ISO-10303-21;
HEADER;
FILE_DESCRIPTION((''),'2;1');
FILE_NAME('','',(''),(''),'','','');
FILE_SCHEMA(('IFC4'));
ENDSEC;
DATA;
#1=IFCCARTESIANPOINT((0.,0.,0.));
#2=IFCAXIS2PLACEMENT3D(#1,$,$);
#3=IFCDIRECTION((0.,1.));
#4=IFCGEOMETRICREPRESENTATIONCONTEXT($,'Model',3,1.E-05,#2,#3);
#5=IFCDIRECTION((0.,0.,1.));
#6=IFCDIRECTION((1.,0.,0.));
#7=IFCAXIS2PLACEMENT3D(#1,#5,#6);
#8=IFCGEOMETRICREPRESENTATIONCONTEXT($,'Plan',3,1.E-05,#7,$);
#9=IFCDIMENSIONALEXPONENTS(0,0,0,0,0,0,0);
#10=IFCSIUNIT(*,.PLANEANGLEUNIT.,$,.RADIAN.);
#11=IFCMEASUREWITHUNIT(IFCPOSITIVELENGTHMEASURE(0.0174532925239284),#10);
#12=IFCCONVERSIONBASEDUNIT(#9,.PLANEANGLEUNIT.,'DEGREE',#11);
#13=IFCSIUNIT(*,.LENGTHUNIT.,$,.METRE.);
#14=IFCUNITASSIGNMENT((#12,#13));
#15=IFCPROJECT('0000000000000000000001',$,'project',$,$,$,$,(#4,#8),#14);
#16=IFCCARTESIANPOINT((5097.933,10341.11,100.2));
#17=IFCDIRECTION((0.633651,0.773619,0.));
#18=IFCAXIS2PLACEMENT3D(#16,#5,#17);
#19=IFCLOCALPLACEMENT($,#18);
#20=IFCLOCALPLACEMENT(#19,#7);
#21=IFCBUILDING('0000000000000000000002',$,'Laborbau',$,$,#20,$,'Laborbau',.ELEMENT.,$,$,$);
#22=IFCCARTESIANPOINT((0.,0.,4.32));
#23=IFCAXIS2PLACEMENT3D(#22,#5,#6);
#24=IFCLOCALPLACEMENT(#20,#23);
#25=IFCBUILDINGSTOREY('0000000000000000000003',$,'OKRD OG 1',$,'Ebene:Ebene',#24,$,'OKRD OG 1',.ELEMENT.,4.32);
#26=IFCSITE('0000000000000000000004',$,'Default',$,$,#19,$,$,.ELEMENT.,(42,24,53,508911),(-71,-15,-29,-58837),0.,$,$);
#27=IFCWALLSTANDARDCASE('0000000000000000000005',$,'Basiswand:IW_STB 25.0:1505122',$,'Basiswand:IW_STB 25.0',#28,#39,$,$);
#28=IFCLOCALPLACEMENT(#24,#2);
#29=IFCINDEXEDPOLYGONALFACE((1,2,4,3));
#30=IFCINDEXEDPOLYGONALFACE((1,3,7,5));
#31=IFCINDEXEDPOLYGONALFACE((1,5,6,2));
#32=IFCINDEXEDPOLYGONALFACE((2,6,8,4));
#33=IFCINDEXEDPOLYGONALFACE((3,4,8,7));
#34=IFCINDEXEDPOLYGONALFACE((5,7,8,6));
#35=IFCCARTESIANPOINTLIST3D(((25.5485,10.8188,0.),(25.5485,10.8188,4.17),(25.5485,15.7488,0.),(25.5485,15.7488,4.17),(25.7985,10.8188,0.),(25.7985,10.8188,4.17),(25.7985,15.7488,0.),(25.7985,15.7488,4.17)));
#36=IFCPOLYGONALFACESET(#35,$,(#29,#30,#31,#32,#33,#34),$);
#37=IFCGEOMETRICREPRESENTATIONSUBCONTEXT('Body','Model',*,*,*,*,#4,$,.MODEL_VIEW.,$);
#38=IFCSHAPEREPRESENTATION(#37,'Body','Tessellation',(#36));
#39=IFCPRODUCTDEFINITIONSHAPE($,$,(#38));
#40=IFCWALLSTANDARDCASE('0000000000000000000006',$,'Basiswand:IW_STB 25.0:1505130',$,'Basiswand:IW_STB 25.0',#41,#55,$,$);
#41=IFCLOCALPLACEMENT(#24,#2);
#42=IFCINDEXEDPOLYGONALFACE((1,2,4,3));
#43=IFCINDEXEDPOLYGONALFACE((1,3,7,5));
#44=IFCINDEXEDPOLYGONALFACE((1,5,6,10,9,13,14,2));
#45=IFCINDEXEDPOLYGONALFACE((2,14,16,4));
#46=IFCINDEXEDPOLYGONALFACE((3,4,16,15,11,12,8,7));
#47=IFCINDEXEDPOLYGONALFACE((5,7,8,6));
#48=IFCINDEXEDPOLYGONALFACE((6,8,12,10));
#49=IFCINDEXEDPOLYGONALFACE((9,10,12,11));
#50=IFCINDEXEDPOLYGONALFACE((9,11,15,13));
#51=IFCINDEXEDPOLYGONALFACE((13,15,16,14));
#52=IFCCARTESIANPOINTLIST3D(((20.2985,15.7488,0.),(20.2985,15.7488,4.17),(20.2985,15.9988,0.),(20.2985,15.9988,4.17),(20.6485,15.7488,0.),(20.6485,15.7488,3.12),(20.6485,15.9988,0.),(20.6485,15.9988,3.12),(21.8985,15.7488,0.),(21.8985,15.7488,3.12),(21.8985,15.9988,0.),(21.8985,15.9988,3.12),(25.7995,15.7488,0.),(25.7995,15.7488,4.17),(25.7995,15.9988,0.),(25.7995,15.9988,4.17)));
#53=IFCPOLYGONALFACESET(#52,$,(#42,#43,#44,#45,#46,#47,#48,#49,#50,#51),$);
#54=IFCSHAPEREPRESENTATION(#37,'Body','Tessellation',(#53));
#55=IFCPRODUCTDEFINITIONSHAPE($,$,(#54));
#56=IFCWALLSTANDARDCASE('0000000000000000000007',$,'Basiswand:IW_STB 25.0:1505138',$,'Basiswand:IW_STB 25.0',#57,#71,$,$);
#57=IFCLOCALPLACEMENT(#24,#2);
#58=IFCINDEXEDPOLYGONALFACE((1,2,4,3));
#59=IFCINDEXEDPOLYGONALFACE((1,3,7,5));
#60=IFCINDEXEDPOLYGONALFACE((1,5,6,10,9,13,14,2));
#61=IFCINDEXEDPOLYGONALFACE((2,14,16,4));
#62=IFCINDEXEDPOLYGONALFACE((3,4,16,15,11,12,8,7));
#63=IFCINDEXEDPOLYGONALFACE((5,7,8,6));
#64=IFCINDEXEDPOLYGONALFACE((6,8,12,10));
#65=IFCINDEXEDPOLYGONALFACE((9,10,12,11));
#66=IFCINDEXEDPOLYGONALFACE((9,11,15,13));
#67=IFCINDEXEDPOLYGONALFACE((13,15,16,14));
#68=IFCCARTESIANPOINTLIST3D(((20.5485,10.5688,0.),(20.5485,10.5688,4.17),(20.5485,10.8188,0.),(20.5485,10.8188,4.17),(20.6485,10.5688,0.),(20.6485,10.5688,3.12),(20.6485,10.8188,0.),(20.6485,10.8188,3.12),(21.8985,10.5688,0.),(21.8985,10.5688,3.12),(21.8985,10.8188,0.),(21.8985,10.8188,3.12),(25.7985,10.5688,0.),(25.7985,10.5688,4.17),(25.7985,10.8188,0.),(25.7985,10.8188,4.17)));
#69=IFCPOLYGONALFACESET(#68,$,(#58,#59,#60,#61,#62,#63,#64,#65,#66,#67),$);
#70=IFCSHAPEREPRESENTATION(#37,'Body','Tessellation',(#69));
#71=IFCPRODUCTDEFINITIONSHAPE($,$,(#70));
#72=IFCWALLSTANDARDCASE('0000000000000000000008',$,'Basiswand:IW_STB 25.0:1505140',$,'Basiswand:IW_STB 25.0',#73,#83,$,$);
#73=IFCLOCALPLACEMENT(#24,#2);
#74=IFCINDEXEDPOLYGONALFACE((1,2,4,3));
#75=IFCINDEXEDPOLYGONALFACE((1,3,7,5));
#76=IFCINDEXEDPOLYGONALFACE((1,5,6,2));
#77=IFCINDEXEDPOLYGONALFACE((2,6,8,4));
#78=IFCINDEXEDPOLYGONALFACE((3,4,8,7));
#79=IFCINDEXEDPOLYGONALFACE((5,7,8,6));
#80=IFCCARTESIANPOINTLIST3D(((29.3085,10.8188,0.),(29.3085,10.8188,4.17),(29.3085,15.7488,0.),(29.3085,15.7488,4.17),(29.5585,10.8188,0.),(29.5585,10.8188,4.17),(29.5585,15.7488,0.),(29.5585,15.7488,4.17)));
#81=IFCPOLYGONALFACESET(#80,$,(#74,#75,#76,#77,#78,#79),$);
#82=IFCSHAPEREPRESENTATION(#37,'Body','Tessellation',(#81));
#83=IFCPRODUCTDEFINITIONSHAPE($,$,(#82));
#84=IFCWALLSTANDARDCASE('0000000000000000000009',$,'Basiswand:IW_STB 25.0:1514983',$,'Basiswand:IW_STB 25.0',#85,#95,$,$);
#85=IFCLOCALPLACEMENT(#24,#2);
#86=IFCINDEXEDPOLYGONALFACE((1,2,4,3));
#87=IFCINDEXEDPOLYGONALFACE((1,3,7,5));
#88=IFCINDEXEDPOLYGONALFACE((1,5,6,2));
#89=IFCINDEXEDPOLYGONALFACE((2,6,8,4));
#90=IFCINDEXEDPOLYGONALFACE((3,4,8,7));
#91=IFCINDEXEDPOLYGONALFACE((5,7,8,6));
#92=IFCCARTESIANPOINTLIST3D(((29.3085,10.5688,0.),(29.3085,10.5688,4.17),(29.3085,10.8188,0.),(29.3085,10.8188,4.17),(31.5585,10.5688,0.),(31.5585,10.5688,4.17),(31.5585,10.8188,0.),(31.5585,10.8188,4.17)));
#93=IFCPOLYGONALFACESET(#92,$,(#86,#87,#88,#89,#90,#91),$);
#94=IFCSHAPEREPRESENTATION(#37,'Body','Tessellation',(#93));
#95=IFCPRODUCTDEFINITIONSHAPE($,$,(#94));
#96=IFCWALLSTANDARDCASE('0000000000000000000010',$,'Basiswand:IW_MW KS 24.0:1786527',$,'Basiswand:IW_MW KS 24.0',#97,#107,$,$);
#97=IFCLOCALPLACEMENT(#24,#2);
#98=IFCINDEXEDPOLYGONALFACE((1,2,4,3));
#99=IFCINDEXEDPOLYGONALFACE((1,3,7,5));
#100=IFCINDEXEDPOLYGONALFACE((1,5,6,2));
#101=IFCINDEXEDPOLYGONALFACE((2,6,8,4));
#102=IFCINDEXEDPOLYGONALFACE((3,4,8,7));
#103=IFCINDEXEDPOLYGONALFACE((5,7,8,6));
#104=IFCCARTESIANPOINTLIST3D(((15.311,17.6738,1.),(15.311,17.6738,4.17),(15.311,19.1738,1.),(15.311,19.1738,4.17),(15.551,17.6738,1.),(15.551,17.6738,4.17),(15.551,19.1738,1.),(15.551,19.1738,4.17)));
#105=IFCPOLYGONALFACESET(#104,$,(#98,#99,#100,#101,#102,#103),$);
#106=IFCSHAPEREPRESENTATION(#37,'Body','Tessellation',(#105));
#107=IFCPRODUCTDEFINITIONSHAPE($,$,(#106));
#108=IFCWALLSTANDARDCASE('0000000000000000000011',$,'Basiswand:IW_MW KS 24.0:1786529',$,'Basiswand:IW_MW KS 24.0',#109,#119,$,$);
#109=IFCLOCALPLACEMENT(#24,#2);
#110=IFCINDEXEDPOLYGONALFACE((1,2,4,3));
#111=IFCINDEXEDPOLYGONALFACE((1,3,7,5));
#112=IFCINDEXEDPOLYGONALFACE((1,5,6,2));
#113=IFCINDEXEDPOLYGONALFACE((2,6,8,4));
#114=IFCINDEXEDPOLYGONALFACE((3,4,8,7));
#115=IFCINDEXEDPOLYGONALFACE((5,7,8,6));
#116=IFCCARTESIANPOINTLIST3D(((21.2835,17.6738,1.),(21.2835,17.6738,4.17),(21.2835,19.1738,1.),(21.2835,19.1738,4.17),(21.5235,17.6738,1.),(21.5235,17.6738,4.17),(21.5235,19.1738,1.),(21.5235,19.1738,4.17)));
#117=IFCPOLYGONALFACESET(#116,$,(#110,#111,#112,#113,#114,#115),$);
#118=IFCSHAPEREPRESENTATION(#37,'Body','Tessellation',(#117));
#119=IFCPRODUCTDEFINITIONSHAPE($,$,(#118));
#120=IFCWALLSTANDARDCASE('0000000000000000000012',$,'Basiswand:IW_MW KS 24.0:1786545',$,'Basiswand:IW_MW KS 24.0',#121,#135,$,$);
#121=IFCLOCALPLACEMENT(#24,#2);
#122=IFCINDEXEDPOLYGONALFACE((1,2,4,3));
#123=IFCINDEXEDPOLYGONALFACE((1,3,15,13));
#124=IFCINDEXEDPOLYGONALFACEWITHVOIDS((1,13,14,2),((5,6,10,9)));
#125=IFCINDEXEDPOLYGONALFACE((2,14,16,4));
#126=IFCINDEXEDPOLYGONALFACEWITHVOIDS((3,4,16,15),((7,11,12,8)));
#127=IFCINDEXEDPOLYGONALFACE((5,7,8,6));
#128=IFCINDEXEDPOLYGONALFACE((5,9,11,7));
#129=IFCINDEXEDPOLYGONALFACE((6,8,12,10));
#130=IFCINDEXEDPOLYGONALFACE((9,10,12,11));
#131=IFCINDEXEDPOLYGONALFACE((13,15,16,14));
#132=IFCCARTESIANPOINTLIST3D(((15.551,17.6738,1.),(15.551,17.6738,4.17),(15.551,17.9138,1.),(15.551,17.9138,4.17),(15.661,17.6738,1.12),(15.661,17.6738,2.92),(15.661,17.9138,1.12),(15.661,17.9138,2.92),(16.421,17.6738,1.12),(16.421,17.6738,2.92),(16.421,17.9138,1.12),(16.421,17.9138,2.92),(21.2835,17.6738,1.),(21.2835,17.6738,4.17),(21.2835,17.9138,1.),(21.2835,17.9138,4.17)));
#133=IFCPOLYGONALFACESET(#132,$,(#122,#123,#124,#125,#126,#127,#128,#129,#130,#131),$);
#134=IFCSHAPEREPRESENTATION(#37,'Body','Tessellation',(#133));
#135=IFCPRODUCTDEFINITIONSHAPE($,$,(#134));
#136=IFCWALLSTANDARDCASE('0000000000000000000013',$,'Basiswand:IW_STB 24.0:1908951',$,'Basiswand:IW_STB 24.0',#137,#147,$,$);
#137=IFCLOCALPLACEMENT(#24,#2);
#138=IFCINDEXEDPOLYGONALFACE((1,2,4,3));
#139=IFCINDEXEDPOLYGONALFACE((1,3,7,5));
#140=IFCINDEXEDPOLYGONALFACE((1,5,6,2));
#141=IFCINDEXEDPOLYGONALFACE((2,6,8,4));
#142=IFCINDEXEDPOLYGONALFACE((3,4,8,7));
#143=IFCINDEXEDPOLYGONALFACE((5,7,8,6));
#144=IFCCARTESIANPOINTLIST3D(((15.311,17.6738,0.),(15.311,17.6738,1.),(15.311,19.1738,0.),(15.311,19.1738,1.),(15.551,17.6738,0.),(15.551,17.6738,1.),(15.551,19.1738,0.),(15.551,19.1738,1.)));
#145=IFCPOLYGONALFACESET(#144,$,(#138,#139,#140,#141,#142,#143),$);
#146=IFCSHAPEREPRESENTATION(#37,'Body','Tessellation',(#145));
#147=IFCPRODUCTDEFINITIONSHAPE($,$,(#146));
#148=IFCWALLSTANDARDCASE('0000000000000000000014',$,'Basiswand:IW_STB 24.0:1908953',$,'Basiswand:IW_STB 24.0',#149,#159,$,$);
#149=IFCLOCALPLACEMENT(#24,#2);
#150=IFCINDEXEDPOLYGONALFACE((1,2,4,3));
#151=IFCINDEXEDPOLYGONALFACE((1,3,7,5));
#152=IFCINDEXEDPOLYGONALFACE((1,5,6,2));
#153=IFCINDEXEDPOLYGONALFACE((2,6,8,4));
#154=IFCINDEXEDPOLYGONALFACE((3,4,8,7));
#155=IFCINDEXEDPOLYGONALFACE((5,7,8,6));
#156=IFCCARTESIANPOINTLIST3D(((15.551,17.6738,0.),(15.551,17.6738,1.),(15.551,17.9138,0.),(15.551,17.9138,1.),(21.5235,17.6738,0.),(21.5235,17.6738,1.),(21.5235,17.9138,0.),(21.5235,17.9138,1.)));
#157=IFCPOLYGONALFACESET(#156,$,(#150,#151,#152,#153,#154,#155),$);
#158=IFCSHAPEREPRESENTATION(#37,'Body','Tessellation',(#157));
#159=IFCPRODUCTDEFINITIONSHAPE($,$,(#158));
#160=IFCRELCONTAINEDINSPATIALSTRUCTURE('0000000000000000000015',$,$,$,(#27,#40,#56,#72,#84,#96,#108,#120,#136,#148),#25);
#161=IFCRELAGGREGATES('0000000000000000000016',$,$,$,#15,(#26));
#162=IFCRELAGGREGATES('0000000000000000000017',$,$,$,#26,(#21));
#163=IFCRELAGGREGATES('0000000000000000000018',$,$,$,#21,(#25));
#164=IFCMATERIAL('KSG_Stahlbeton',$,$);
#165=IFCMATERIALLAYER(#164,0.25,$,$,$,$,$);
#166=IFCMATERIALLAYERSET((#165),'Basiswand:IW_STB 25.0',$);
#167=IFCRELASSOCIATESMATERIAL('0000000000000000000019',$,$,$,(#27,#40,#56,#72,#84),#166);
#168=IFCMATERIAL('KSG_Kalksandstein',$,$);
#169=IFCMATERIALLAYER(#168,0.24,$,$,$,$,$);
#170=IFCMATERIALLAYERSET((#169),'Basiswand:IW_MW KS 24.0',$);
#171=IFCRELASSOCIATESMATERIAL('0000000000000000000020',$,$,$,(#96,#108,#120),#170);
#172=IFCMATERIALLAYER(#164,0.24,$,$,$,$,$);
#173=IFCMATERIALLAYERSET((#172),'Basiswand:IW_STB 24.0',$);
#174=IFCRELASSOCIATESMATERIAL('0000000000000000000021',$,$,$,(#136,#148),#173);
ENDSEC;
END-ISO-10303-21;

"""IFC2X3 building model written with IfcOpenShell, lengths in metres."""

from ifc_helpers import new_model, entity, si_unit, converted_unit, direction, frame, frame_2d, origin, origin_with_axes, place, context, subcontext, project, spatial, rectangle, extrude, material, layer, layer_set, layer_usage, element, save


model = new_model("IFC2X3")

# Units and contexts
model_context = context("Model", 3, precision=1e-05, world=origin(), true_north=direction((0.0, 1.0)))
plan_context = context("Plan", 3, precision=1e-05, world=origin_with_axes())
body_context = subcontext(model_context, "Body", "Model", "MODEL_VIEW")
ifc_project = project(units=[converted_unit("PLANEANGLEUNIT", "DEGREE", entity("IfcPositiveLengthMeasure", 0.0174532925239284), si_unit("PLANEANGLEUNIT", "RADIAN"), dimensions=[0, 0, 0, 0, 0, 0, 0]), si_unit("LENGTHUNIT", "METRE")], contexts=[model_context, plan_context])

# Site, building, storey
site_placement = place(None, frame((5097.933, 10341.11, 100.2), z_axis=(0.0, 0.0, 1.0), x_axis=(0.633651, 0.773619, 0.0)))
site = spatial("IfcSite", under=ifc_project, at=site_placement, Name="Default", CompositionType="ELEMENT", RefLatitude=(42, 24, 53, 508911), RefLongitude=(-71, -15, -29, -58837), RefElevation=0.0)
building_placement = place(site_placement, origin_with_axes())
building = spatial("IfcBuilding", under=site, at=building_placement, Name="Laborbau", LongName="Laborbau", CompositionType="ELEMENT")
storey_placement = place(building_placement, frame((0.0, 0.0, 4.32), z_axis=(0.0, 0.0, 1.0), x_axis=(1.0, 0.0, 0.0)))
storey = spatial("IfcBuildingStorey", under=building, at=storey_placement, Name="OKRD OG 1", ObjectType="Ebene:Ebene", LongName="OKRD OG 1", CompositionType="ELEMENT", Elevation=4.32)

# Wall
ifc_material_1 = material(Name="KSG_Stahlbeton")
ifc_layer_1 = layer(ifc_material_1, 0.25)
ifc_layer_set_1 = layer_set([ifc_layer_1], Name="Basiswand:IW_STB 25.0")
ifc_layer_usage_1 = layer_usage(ifc_layer_set_1, "AXIS2", "NEGATIVE", 0.125)
wall_1_placement = place(storey_placement, frame((25.6735, 10.8188, 0.0), z_axis=(0.0, 0.0, 1.0), x_axis=(0.0, 1.0, 0.0)))
element("IfcWallStandardCase", 1, at=wall_1_placement, inside=storey, material=ifc_layer_usage_1, Name="Basiswand:IW_STB 25.0:1505122", ObjectType="Basiswand:IW_STB 25.0", context=body_context, shape_type="SweptSolid", body=[
    extrude(rectangle(XDim=4.93, YDim=0.25, at=frame_2d((2.465, 0.0), x_axis=(-1.0, 0.0))), origin(), (0.0, 0.0, 1.0), 4.17),
])

# Walls, openings
ifc_layer_usage_2 = layer_usage(ifc_layer_set_1, "AXIS2", "NEGATIVE", 0.125)
wall_2_placement = place(storey_placement, frame((20.2985, 15.8738, 0.0), z_axis=(0.0, 0.0, 1.0), x_axis=(1.0, 0.0, 0.0)))
wall_2 = element("IfcWallStandardCase", 2, at=wall_2_placement, inside=storey, material=ifc_layer_usage_2, Name="Basiswand:IW_STB 25.0:1505130", ObjectType="Basiswand:IW_STB 25.0", context=body_context, shape_type="SweptSolid", body=[
    extrude(rectangle(XDim=5.501, YDim=0.25, at=frame_2d((2.7505, 0.0), x_axis=(-1.0, 0.0))), origin(), (0.0, 0.0, 1.0), 4.17),
])
opening_1_placement = place(wall_2_placement, frame((-20.2985, -15.8738, 0.0), z_axis=(0.0, 0.0, 1.0), x_axis=(1.0, 0.0, 0.0)))
element("IfcOpeningElement", 3, at=opening_1_placement, cuts=wall_2, ObjectType="Opening", context=body_context, shape_type="SweptSolid", body=[
    extrude(rectangle(XDim=3.12, YDim=1.25, at=frame_2d((0.0, 0.0), x_axis=(1.0, 0.0))), frame((21.2735, 14.2248, 1.56), z_axis=(0.0, 1.0, 0.0), x_axis=(0.0, 0.0, 1.0)), (0.0, 0.0, 1.0), 3.048),
])
opening_2_placement = place(wall_2_placement, frame((1.6, 0.125, 0.0), z_axis=(0.0, 0.0, 1.0), x_axis=(1.0, 0.0, 0.0)))
element("IfcOpeningElement", 4, at=opening_2_placement, cuts=wall_2, ObjectType="Opening", context=body_context, shape_type="SweptSolid", body=[
    extrude(rectangle(XDim=3.12, YDim=1.25, at=frame_2d((1.56, 0.625), x_axis=(1.0, 0.0))), frame((0.0, 0.0, 0.0), z_axis=(0.0, -1.0, 0.0), x_axis=(0.0, 0.0, 1.0)), (0.0, 0.0, 1.0), 0.25),
])
ifc_layer_usage_3 = layer_usage(ifc_layer_set_1, "AXIS2", "NEGATIVE", 0.125)
wall_3_placement = place(storey_placement, frame((20.5485, 10.6938, 0.0), z_axis=(0.0, 0.0, 1.0), x_axis=(1.0, 0.0, 0.0)))
wall_3 = element("IfcWallStandardCase", 5, at=wall_3_placement, inside=storey, material=ifc_layer_usage_3, Name="Basiswand:IW_STB 25.0:1505138", ObjectType="Basiswand:IW_STB 25.0", context=body_context, shape_type="SweptSolid", body=[
    extrude(rectangle(XDim=5.25, YDim=0.25, at=frame_2d((2.625, 0.0), x_axis=(-1.0, 0.0))), origin(), (0.0, 0.0, 1.0), 4.17),
])
opening_3_placement = place(wall_3_placement, frame((-20.5485, -10.6938, 0.0), z_axis=(0.0, 0.0, 1.0), x_axis=(1.0, 0.0, 0.0)))
element("IfcOpeningElement", 6, at=opening_3_placement, cuts=wall_3, ObjectType="Opening", context=body_context, shape_type="SweptSolid", body=[
    extrude(rectangle(XDim=3.12, YDim=1.25, at=frame_2d((0.0, 0.0), x_axis=(1.0, 0.0))), frame((21.2735, 9.2948, 1.56), z_axis=(0.0, 1.0, 0.0), x_axis=(0.0, 0.0, 1.0)), (0.0, 0.0, 1.0), 3.048),
])
opening_4_placement = place(wall_3_placement, frame((0.1, -0.125, 0.0), z_axis=(0.0, 0.0, 1.0), x_axis=(1.0, 0.0, 0.0)))
element("IfcOpeningElement", 7, at=opening_4_placement, cuts=wall_3, ObjectType="Opening", context=body_context, shape_type="SweptSolid", body=[
    extrude(rectangle(XDim=3.12, YDim=1.25, at=frame_2d((1.56, 0.625), x_axis=(1.0, 0.0))), frame((0.0, 0.0, 0.0), z_axis=(0.0, 1.0, 0.0), x_axis=(0.0, 0.0, 1.0)), (0.0, 0.0, 1.0), 0.25),
])

# Walls
ifc_layer_usage_4 = layer_usage(ifc_layer_set_1, "AXIS2", "NEGATIVE", 0.125)
wall_4_placement = place(storey_placement, frame((29.4335, 10.8188, 0.0), z_axis=(0.0, 0.0, 1.0), x_axis=(0.0, 1.0, 0.0)))
element("IfcWallStandardCase", 8, at=wall_4_placement, inside=storey, material=ifc_layer_usage_4, Name="Basiswand:IW_STB 25.0:1505140", ObjectType="Basiswand:IW_STB 25.0", context=body_context, shape_type="SweptSolid", body=[
    extrude(rectangle(XDim=4.93, YDim=0.25, at=frame_2d((2.465, 0.0), x_axis=(-1.0, 0.0))), origin(), (0.0, 0.0, 1.0), 4.17),
])
ifc_layer_usage_5 = layer_usage(ifc_layer_set_1, "AXIS2", "NEGATIVE", 0.125)
wall_5_placement = place(storey_placement, frame((29.3085, 10.6938, 0.0), z_axis=(0.0, 0.0, 1.0), x_axis=(1.0, 0.0, 0.0)))
element("IfcWallStandardCase", 9, at=wall_5_placement, inside=storey, material=ifc_layer_usage_5, Name="Basiswand:IW_STB 25.0:1514983", ObjectType="Basiswand:IW_STB 25.0", context=body_context, shape_type="SweptSolid", body=[
    extrude(rectangle(XDim=2.25, YDim=0.25, at=frame_2d((1.125, 0.0), x_axis=(-1.0, 0.0))), origin(), (0.0, 0.0, 1.0), 4.17),
])
ifc_material_2 = material(Name="KSG_Kalksandstein")
ifc_layer_2 = layer(ifc_material_2, 0.24)
ifc_layer_set_2 = layer_set([ifc_layer_2], Name="Basiswand:IW_MW KS 24.0")
ifc_layer_usage_6 = layer_usage(ifc_layer_set_2, "AXIS2", "POSITIVE", -0.12)
wall_6_placement = place(storey_placement, frame((15.431, 19.1738, 1.0), z_axis=(0.0, 0.0, 1.0), x_axis=(0.0, -1.0, 0.0)))
element("IfcWallStandardCase", 10, at=wall_6_placement, inside=storey, material=ifc_layer_usage_6, Name="Basiswand:IW_MW KS 24.0:1786527", ObjectType="Basiswand:IW_MW KS 24.0", context=body_context, shape_type="SweptSolid", body=[
    extrude(rectangle(XDim=1.5, YDim=0.24, at=frame_2d((0.75, 0.0), x_axis=(-1.0, 0.0))), origin(), (0.0, 0.0, 1.0), 3.17),
])
ifc_layer_usage_7 = layer_usage(ifc_layer_set_2, "AXIS2", "POSITIVE", -0.12)
wall_7_placement = place(storey_placement, frame((21.4035, 17.6738, 1.0), z_axis=(0.0, 0.0, 1.0), x_axis=(0.0, 1.0, 0.0)))
element("IfcWallStandardCase", 11, at=wall_7_placement, inside=storey, material=ifc_layer_usage_7, Name="Basiswand:IW_MW KS 24.0:1786529", ObjectType="Basiswand:IW_MW KS 24.0", context=body_context, shape_type="SweptSolid", body=[
    extrude(rectangle(XDim=1.5, YDim=0.24, at=frame_2d((0.75, 0.0), x_axis=(-1.0, 0.0))), origin(), (0.0, 0.0, 1.0), 3.17),
])

# Wall, openings
ifc_layer_usage_8 = layer_usage(ifc_layer_set_2, "AXIS2", "POSITIVE", -0.12)
wall_8_placement = place(storey_placement, frame((15.551, 17.7938, 1.0), z_axis=(0.0, 0.0, 1.0), x_axis=(1.0, 0.0, 0.0)))
wall_8 = element("IfcWallStandardCase", 12, at=wall_8_placement, inside=storey, material=ifc_layer_usage_8, Name="Basiswand:IW_MW KS 24.0:1786545", ObjectType="Basiswand:IW_MW KS 24.0", context=body_context, shape_type="SweptSolid", body=[
    extrude(rectangle(XDim=5.7325, YDim=0.24, at=frame_2d((2.8662, 0.0), x_axis=(-1.0, 0.0))), origin(), (0.0, 0.0, 1.0), 3.17),
])
opening_5_placement = place(wall_8_placement, frame((-15.551, -17.7938, -1.0), z_axis=(0.0, 0.0, 1.0), x_axis=(1.0, 0.0, 0.0)))
element("IfcOpeningElement", 13, at=opening_5_placement, cuts=wall_8, ObjectType="Opening", context=body_context, shape_type="SweptSolid", body=[
    extrude(rectangle(XDim=1.8, YDim=0.76, at=frame_2d((0.0, 0.0), x_axis=(0.0, 1.0))), frame((16.041, 16.3898, 2.02), z_axis=(0.0, 1.0, 0.0), x_axis=(-1.0, 0.0, 0.0)), (0.0, 0.0, 1.0), 3.048),
])
opening_6_placement = place(wall_8_placement, frame((0.87, 0.12, 0.12), z_axis=(0.0, 0.0, 1.0), x_axis=(1.0, 0.0, 0.0)))
element("IfcOpeningElement", 14, at=opening_6_placement, cuts=wall_8, ObjectType="Opening", context=body_context, shape_type="SweptSolid", body=[
    extrude(rectangle(XDim=1.8, YDim=0.76, at=frame_2d((0.9, 0.38), x_axis=(1.0, 0.0))), frame((0.0, 0.0, 0.0), z_axis=(0.0, -1.0, 0.0), x_axis=(0.0, 0.0, 1.0)), (0.0, 0.0, 1.0), 0.24),
])

# Walls
ifc_layer_3 = layer(ifc_material_1, 0.24)
ifc_layer_set_3 = layer_set([ifc_layer_3], Name="Basiswand:IW_STB 24.0")
ifc_layer_usage_9 = layer_usage(ifc_layer_set_3, "AXIS2", "NEGATIVE", 0.12)
wall_9_placement = place(storey_placement, frame((15.431, 19.1738, 0.0), z_axis=(0.0, 0.0, 1.0), x_axis=(0.0, -1.0, 0.0)))
element("IfcWallStandardCase", 15, at=wall_9_placement, inside=storey, material=ifc_layer_usage_9, Name="Basiswand:IW_STB 24.0:1908951", ObjectType="Basiswand:IW_STB 24.0", context=body_context, shape_type="SweptSolid", body=[
    extrude(rectangle(XDim=1.5, YDim=0.24, at=frame_2d((0.75, 0.0), x_axis=(-1.0, 0.0))), origin(), (0.0, 0.0, 1.0), 1.0),
])
ifc_layer_usage_10 = layer_usage(ifc_layer_set_3, "AXIS2", "NEGATIVE", 0.12)
wall_10_placement = place(storey_placement, frame((15.551, 17.7938, 0.0), z_axis=(0.0, 0.0, 1.0), x_axis=(1.0, 0.0, 0.0)))
element("IfcWallStandardCase", 16, at=wall_10_placement, inside=storey, material=ifc_layer_usage_10, Name="Basiswand:IW_STB 24.0:1908953", ObjectType="Basiswand:IW_STB 24.0", context=body_context, shape_type="SweptSolid", body=[
    extrude(rectangle(XDim=5.9725, YDim=0.24, at=frame_2d((2.9863, 0.0), x_axis=(-1.0, 0.0))), origin(), (0.0, 0.0, 1.0), 1.0),
])

save(model, "model.ifc")
